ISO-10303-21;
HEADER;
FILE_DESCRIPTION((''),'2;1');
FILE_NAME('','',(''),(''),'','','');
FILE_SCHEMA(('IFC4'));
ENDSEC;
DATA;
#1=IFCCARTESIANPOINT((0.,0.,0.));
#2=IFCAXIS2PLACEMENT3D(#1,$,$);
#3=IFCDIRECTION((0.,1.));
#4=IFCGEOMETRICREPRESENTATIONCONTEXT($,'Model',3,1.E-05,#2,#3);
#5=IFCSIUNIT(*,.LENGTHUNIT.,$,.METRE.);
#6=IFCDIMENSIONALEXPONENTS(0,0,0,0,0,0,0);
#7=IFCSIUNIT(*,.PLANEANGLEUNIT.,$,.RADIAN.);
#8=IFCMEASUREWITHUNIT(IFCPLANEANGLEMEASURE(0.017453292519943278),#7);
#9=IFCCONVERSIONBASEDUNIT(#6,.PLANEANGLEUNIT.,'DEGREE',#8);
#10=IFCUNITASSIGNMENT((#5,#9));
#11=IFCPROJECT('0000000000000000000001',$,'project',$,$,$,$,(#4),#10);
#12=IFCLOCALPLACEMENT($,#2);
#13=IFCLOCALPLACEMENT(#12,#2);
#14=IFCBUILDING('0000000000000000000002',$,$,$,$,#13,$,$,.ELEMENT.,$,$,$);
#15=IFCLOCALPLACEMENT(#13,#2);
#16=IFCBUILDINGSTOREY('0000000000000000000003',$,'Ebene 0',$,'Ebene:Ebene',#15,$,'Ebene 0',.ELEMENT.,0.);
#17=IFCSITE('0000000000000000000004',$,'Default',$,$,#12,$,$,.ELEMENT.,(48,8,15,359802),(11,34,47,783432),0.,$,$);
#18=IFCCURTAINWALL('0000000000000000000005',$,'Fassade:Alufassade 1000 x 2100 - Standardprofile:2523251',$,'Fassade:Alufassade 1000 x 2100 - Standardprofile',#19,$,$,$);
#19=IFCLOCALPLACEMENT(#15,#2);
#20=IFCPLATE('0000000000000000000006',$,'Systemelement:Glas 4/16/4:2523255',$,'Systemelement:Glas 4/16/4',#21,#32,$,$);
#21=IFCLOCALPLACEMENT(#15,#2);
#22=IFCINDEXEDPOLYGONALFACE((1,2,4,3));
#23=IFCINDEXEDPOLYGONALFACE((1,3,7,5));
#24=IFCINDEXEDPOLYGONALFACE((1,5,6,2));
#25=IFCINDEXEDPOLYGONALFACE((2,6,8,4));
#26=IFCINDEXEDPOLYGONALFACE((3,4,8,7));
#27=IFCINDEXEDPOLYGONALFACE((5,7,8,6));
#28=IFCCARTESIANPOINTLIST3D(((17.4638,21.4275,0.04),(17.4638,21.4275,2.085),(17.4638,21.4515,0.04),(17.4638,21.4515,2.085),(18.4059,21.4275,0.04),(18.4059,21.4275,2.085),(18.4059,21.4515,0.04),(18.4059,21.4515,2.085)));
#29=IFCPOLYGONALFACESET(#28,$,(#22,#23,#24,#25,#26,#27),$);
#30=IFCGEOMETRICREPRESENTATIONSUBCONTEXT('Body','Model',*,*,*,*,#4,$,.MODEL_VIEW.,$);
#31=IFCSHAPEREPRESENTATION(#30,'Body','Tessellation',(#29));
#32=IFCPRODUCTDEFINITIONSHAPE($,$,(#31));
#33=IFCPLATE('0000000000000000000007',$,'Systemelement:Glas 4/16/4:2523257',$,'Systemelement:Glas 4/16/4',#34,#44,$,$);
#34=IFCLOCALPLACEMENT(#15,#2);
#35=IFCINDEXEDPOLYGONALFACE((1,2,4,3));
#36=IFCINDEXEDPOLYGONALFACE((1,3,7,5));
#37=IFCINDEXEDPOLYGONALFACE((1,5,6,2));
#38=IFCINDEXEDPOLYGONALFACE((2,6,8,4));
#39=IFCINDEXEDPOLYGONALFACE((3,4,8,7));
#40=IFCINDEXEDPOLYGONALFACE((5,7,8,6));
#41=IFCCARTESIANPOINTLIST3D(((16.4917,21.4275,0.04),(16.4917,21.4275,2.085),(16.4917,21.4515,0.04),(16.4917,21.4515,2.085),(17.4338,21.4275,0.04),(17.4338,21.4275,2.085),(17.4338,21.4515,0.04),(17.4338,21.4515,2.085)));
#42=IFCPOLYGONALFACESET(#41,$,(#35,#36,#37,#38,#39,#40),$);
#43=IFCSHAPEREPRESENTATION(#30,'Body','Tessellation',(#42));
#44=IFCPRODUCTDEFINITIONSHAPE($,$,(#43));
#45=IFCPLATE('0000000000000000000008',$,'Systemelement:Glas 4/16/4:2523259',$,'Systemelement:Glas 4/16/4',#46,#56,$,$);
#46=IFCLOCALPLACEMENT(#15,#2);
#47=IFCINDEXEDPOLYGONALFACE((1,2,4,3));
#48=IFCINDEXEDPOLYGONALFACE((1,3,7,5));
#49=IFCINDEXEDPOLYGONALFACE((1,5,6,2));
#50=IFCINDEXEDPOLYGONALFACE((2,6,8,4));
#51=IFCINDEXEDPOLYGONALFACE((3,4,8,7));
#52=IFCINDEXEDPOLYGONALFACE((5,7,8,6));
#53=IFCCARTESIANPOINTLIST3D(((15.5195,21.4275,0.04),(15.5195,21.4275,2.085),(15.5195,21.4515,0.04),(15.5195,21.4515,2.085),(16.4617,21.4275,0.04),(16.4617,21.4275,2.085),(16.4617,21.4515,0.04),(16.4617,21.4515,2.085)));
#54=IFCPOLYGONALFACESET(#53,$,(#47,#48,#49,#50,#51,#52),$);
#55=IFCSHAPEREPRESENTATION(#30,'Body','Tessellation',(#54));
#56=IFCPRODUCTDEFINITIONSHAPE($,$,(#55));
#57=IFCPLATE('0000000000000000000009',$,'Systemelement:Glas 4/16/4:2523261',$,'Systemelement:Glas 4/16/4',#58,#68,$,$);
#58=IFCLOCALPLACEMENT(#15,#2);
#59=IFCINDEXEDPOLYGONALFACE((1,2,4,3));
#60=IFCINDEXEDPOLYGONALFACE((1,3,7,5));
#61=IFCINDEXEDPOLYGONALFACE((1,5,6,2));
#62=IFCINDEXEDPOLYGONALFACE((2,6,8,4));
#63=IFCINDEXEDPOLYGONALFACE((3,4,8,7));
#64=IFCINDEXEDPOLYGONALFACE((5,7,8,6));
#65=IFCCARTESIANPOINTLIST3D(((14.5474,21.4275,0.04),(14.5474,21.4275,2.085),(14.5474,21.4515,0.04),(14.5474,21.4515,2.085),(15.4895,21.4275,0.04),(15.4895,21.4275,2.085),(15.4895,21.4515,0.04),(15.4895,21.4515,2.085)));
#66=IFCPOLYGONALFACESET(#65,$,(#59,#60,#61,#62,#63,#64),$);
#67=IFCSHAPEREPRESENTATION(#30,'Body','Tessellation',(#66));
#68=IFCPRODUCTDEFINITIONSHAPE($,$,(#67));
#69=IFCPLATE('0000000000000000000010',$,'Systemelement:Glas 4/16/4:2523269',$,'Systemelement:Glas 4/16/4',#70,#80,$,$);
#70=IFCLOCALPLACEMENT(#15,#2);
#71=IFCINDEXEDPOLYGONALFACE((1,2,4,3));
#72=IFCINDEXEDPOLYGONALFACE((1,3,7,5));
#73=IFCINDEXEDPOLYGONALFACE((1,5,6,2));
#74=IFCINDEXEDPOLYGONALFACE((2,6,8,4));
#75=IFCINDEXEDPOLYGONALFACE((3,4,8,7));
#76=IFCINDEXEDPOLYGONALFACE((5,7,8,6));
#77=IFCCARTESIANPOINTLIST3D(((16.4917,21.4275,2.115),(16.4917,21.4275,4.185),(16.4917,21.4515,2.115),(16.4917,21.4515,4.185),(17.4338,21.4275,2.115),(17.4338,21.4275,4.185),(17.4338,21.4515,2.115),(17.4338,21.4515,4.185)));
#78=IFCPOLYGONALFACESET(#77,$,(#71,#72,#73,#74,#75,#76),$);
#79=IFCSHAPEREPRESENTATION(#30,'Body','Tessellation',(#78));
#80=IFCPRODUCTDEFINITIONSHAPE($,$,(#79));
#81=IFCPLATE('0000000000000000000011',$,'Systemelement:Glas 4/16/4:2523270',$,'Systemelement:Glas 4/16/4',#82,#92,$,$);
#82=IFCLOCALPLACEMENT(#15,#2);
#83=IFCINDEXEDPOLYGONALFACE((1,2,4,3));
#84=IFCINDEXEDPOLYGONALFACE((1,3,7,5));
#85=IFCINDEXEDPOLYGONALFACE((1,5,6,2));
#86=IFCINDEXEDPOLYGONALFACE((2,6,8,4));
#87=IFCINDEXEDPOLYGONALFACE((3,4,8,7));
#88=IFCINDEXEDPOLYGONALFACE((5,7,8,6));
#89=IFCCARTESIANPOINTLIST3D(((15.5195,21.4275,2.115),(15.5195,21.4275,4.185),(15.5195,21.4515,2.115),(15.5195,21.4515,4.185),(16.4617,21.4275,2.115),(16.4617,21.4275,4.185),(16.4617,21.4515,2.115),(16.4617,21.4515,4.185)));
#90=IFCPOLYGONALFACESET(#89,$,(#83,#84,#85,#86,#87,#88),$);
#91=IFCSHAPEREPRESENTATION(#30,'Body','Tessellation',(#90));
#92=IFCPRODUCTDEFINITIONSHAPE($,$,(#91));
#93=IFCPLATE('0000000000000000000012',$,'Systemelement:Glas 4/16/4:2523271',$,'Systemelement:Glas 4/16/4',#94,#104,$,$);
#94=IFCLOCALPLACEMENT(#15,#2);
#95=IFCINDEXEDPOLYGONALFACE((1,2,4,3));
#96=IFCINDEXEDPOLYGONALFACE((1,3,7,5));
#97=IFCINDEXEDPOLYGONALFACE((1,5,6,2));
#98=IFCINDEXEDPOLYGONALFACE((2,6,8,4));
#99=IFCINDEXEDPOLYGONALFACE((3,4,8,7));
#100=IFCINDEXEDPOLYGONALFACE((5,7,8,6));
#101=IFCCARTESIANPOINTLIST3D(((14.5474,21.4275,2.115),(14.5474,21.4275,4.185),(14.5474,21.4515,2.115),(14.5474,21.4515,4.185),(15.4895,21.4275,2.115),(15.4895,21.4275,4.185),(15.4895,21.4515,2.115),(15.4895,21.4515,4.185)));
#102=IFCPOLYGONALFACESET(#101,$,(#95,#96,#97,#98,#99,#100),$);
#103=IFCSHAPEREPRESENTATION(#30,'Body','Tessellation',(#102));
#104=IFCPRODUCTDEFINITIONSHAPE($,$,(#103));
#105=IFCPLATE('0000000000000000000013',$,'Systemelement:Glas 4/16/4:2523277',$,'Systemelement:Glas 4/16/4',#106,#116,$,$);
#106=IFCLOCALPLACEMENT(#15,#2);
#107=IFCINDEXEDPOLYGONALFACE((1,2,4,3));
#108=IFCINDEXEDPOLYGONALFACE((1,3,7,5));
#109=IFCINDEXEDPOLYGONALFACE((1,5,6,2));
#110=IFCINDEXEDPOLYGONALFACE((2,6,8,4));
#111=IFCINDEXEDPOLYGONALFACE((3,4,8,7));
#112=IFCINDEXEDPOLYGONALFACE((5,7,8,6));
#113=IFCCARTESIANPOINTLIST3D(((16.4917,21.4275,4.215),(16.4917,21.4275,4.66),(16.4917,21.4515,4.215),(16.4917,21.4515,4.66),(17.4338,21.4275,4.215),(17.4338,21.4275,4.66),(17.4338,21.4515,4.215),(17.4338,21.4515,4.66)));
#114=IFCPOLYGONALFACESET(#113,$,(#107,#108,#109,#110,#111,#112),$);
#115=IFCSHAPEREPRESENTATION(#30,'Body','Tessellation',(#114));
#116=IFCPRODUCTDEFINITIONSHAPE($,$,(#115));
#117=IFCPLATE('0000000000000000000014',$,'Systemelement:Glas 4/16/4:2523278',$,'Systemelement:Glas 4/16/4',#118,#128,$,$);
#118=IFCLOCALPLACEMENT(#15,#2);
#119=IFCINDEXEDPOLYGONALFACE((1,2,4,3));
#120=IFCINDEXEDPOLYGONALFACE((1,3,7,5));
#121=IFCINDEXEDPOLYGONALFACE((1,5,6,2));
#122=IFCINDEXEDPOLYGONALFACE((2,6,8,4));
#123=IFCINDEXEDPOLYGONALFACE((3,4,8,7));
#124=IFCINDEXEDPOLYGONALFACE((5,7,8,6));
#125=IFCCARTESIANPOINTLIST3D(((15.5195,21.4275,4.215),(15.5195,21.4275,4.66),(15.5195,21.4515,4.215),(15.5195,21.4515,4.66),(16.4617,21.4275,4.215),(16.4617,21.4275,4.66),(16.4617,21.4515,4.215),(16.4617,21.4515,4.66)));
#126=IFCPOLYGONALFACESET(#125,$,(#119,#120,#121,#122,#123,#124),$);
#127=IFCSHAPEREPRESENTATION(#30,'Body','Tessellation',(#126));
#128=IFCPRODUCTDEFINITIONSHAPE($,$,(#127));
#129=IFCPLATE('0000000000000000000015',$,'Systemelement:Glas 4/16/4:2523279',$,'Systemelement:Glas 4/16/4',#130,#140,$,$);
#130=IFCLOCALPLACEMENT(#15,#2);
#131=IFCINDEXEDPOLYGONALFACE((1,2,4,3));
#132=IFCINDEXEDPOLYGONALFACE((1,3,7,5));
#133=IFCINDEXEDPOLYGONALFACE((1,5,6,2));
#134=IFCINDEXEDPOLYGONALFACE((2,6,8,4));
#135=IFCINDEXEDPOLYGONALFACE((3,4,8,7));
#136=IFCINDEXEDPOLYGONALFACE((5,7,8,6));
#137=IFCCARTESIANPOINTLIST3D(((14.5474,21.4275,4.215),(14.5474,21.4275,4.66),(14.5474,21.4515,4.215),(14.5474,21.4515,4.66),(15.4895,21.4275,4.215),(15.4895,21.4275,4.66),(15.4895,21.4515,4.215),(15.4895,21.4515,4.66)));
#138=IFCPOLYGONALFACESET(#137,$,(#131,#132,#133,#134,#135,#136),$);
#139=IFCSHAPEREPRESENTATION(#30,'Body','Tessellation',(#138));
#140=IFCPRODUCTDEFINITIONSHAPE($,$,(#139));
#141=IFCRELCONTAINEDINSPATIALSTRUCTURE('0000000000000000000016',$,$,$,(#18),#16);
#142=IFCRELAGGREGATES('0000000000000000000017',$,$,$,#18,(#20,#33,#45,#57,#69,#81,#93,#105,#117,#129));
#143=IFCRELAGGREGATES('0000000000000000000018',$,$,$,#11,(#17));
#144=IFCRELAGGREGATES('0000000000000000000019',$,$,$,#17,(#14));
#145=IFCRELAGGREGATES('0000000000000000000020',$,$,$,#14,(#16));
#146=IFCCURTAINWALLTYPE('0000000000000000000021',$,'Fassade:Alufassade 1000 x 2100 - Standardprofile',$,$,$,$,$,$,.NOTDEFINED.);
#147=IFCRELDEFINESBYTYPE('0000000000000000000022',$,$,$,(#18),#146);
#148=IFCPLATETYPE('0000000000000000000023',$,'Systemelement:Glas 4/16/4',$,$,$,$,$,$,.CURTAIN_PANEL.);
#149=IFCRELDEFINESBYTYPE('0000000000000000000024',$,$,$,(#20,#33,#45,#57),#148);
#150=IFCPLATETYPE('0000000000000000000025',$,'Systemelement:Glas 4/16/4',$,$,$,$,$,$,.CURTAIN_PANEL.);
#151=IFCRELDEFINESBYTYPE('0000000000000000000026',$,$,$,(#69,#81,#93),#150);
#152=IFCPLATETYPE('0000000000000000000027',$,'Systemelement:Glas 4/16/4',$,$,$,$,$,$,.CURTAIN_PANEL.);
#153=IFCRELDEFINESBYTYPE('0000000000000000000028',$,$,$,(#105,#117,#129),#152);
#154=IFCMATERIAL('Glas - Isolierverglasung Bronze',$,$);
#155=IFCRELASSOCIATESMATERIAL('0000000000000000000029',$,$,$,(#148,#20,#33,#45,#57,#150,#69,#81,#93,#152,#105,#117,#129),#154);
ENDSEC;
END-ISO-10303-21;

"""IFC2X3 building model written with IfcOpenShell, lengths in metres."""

from ifc_helpers import new_model, entity, si_unit, converted_unit, direction, frame, origin, origin_2d_with_axis, place, context, subcontext, project, spatial, rectangle, extrude, source, transform, mapped, material, type_object, type_shapes, element, aggregate, save


model = new_model("IFC2X3")

# Units and contexts
model_context = context("Model", 3, precision=1e-05, world=origin(), true_north=direction((0.0, 1.0)))
body_context = subcontext(model_context, "Body", "Model", "MODEL_VIEW")
ifc_project = project(units=[si_unit("LENGTHUNIT", "METRE"), converted_unit("PLANEANGLEUNIT", "DEGREE", entity("IfcPlaneAngleMeasure", 0.017453292519943278), si_unit("PLANEANGLEUNIT", "RADIAN"), dimensions=[0, 0, 0, 0, 0, 0, 0])], contexts=[model_context])

# Site, building, storey
site_placement = place(None, origin())
site = spatial("IfcSite", under=ifc_project, at=site_placement, Name="Default", CompositionType="ELEMENT", RefLatitude=(48, 8, 15, 359802), RefLongitude=(11, 34, 47, 783432), RefElevation=0.0)
building_placement = place(site_placement, origin())
building = spatial("IfcBuilding", under=site, at=building_placement, CompositionType="ELEMENT")
storey_placement = place(building_placement, origin())
storey = spatial("IfcBuildingStorey", under=building, at=storey_placement, Name="Ebene 0", ObjectType="Ebene:Ebene", LongName="Ebene 0", CompositionType="ELEMENT", Elevation=0.0)

# Curtain wall, plates
curtain_wall_type = type_object("IfcCurtainWallType", Name="Fassade:Alufassade 1000 x 2100 - Standardprofile", PredefinedType="NOTDEFINED")
curtain_wall_placement = place(storey_placement, origin())
curtain_wall = element("IfcCurtainWall", 1, at=curtain_wall_placement, inside=storey, type_object=curtain_wall_type, Name="Fassade:Alufassade 1000 x 2100 - Standardprofile:2523251", ObjectType="Fassade:Alufassade 1000 x 2100 - Standardprofile")
ifc_material_1 = material(Name="Glas - Isolierverglasung Bronze")
plate_type_1 = type_object("IfcPlateType", Name="Systemelement:Glas 4/16/4", PredefinedType="CURTAIN_PANEL", material=ifc_material_1)
shared_shape_1 = source(origin(), body_context, "Body", "SweptSolid", [
    extrude(rectangle(XDim=0.024, YDim=0.9421, at=origin_2d_with_axis()), frame((0.0, 0.0, 0.0), z_axis=(0.0, 0.0, 1.0), x_axis=(0.0, 1.0, 0.0)), (0.0, 0.0, 1.0), 2.045),
])
type_shapes(plate_type_1, [shared_shape_1])
plate_1_placement = place(curtain_wall_placement, frame((17.9349, 21.4395, 0.04), z_axis=(0.0, 0.0, 1.0), x_axis=(-1.0, 0.0, 0.0)))
plate_1 = element("IfcPlate", 2, at=plate_1_placement, type_object=plate_type_1, material=ifc_material_1, Name="Systemelement:Glas 4/16/4:2523255", ObjectType="Systemelement:Glas 4/16/4", context=body_context, shape_type="MappedRepresentation", body=[
    mapped(shared_shape_1, transform((0.0, 0.0, 0.0), scale=1.0)),
])
plate_2_placement = place(curtain_wall_placement, frame((16.9627, 21.4395, 0.04), z_axis=(0.0, 0.0, 1.0), x_axis=(-1.0, 0.0, 0.0)))
plate_2 = element("IfcPlate", 3, at=plate_2_placement, type_object=plate_type_1, material=ifc_material_1, Name="Systemelement:Glas 4/16/4:2523257", ObjectType="Systemelement:Glas 4/16/4", context=body_context, shape_type="MappedRepresentation", body=[
    mapped(shared_shape_1, transform((0.0, 0.0, 0.0), scale=1.0)),
])
plate_3_placement = place(curtain_wall_placement, frame((15.9906, 21.4395, 0.04), z_axis=(0.0, 0.0, 1.0), x_axis=(-1.0, 0.0, 0.0)))
plate_3 = element("IfcPlate", 4, at=plate_3_placement, type_object=plate_type_1, material=ifc_material_1, Name="Systemelement:Glas 4/16/4:2523259", ObjectType="Systemelement:Glas 4/16/4", context=body_context, shape_type="MappedRepresentation", body=[
    mapped(shared_shape_1, transform((0.0, 0.0, 0.0), scale=1.0)),
])
plate_4_placement = place(curtain_wall_placement, frame((15.0184, 21.4395, 0.04), z_axis=(0.0, 0.0, 1.0), x_axis=(-1.0, 0.0, 0.0)))
plate_4 = element("IfcPlate", 5, at=plate_4_placement, type_object=plate_type_1, material=ifc_material_1, Name="Systemelement:Glas 4/16/4:2523261", ObjectType="Systemelement:Glas 4/16/4", context=body_context, shape_type="MappedRepresentation", body=[
    mapped(shared_shape_1, transform((0.0, 0.0, 0.0), scale=1.0)),
])
plate_type_2 = type_object("IfcPlateType", Name="Systemelement:Glas 4/16/4", PredefinedType="CURTAIN_PANEL", material=ifc_material_1)
shared_shape_2 = source(origin(), body_context, "Body", "SweptSolid", [
    extrude(rectangle(XDim=0.024, YDim=0.9421, at=origin_2d_with_axis()), frame((0.0, 0.0, 0.0), z_axis=(0.0, 0.0, 1.0), x_axis=(0.0, 1.0, 0.0)), (0.0, 0.0, 1.0), 2.07),
])
type_shapes(plate_type_2, [shared_shape_2])
plate_5_placement = place(curtain_wall_placement, frame((16.9627, 21.4395, 2.115), z_axis=(0.0, 0.0, 1.0), x_axis=(-1.0, 0.0, 0.0)))
plate_5 = element("IfcPlate", 6, at=plate_5_placement, type_object=plate_type_2, material=ifc_material_1, Name="Systemelement:Glas 4/16/4:2523269", ObjectType="Systemelement:Glas 4/16/4", context=body_context, shape_type="MappedRepresentation", body=[
    mapped(shared_shape_2, transform((0.0, 0.0, 0.0), scale=1.0)),
])
plate_6_placement = place(curtain_wall_placement, frame((15.9906, 21.4395, 2.115), z_axis=(0.0, 0.0, 1.0), x_axis=(-1.0, 0.0, 0.0)))
plate_6 = element("IfcPlate", 7, at=plate_6_placement, type_object=plate_type_2, material=ifc_material_1, Name="Systemelement:Glas 4/16/4:2523270", ObjectType="Systemelement:Glas 4/16/4", context=body_context, shape_type="MappedRepresentation", body=[
    mapped(shared_shape_2, transform((0.0, 0.0, 0.0), scale=1.0)),
])
plate_7_placement = place(curtain_wall_placement, frame((15.0184, 21.4395, 2.115), z_axis=(0.0, 0.0, 1.0), x_axis=(-1.0, 0.0, 0.0)))
plate_7 = element("IfcPlate", 8, at=plate_7_placement, type_object=plate_type_2, material=ifc_material_1, Name="Systemelement:Glas 4/16/4:2523271", ObjectType="Systemelement:Glas 4/16/4", context=body_context, shape_type="MappedRepresentation", body=[
    mapped(shared_shape_2, transform((0.0, 0.0, 0.0), scale=1.0)),
])
plate_type_3 = type_object("IfcPlateType", Name="Systemelement:Glas 4/16/4", PredefinedType="CURTAIN_PANEL", material=ifc_material_1)
shared_shape_3 = source(origin(), body_context, "Body", "SweptSolid", [
    extrude(rectangle(XDim=0.024, YDim=0.9421, at=origin_2d_with_axis()), frame((0.0, 0.0, 0.0), z_axis=(0.0, 0.0, 1.0), x_axis=(0.0, 1.0, 0.0)), (0.0, 0.0, 1.0), 0.445),
])
type_shapes(plate_type_3, [shared_shape_3])
plate_8_placement = place(curtain_wall_placement, frame((16.9627, 21.4395, 4.215), z_axis=(0.0, 0.0, 1.0), x_axis=(-1.0, 0.0, 0.0)))
plate_8 = element("IfcPlate", 9, at=plate_8_placement, type_object=plate_type_3, material=ifc_material_1, Name="Systemelement:Glas 4/16/4:2523277", ObjectType="Systemelement:Glas 4/16/4", context=body_context, shape_type="MappedRepresentation", body=[
    mapped(shared_shape_3, transform((0.0, 0.0, 0.0), scale=1.0)),
])
plate_9_placement = place(curtain_wall_placement, frame((15.9906, 21.4395, 4.215), z_axis=(0.0, 0.0, 1.0), x_axis=(-1.0, 0.0, 0.0)))
plate_9 = element("IfcPlate", 10, at=plate_9_placement, type_object=plate_type_3, material=ifc_material_1, Name="Systemelement:Glas 4/16/4:2523278", ObjectType="Systemelement:Glas 4/16/4", context=body_context, shape_type="MappedRepresentation", body=[
    mapped(shared_shape_3, transform((0.0, 0.0, 0.0), scale=1.0)),
])
plate_10_placement = place(curtain_wall_placement, frame((15.0184, 21.4395, 4.215), z_axis=(0.0, 0.0, 1.0), x_axis=(-1.0, 0.0, 0.0)))
plate_10 = element("IfcPlate", 11, at=plate_10_placement, type_object=plate_type_3, material=ifc_material_1, Name="Systemelement:Glas 4/16/4:2523279", ObjectType="Systemelement:Glas 4/16/4", context=body_context, shape_type="MappedRepresentation", body=[
    mapped(shared_shape_3, transform((0.0, 0.0, 0.0), scale=1.0)),
])
aggregate(curtain_wall, [plate_1, plate_2, plate_3, plate_4, plate_5, plate_6, plate_7, plate_8, plate_9, plate_10])

save(model, "model.ifc")
